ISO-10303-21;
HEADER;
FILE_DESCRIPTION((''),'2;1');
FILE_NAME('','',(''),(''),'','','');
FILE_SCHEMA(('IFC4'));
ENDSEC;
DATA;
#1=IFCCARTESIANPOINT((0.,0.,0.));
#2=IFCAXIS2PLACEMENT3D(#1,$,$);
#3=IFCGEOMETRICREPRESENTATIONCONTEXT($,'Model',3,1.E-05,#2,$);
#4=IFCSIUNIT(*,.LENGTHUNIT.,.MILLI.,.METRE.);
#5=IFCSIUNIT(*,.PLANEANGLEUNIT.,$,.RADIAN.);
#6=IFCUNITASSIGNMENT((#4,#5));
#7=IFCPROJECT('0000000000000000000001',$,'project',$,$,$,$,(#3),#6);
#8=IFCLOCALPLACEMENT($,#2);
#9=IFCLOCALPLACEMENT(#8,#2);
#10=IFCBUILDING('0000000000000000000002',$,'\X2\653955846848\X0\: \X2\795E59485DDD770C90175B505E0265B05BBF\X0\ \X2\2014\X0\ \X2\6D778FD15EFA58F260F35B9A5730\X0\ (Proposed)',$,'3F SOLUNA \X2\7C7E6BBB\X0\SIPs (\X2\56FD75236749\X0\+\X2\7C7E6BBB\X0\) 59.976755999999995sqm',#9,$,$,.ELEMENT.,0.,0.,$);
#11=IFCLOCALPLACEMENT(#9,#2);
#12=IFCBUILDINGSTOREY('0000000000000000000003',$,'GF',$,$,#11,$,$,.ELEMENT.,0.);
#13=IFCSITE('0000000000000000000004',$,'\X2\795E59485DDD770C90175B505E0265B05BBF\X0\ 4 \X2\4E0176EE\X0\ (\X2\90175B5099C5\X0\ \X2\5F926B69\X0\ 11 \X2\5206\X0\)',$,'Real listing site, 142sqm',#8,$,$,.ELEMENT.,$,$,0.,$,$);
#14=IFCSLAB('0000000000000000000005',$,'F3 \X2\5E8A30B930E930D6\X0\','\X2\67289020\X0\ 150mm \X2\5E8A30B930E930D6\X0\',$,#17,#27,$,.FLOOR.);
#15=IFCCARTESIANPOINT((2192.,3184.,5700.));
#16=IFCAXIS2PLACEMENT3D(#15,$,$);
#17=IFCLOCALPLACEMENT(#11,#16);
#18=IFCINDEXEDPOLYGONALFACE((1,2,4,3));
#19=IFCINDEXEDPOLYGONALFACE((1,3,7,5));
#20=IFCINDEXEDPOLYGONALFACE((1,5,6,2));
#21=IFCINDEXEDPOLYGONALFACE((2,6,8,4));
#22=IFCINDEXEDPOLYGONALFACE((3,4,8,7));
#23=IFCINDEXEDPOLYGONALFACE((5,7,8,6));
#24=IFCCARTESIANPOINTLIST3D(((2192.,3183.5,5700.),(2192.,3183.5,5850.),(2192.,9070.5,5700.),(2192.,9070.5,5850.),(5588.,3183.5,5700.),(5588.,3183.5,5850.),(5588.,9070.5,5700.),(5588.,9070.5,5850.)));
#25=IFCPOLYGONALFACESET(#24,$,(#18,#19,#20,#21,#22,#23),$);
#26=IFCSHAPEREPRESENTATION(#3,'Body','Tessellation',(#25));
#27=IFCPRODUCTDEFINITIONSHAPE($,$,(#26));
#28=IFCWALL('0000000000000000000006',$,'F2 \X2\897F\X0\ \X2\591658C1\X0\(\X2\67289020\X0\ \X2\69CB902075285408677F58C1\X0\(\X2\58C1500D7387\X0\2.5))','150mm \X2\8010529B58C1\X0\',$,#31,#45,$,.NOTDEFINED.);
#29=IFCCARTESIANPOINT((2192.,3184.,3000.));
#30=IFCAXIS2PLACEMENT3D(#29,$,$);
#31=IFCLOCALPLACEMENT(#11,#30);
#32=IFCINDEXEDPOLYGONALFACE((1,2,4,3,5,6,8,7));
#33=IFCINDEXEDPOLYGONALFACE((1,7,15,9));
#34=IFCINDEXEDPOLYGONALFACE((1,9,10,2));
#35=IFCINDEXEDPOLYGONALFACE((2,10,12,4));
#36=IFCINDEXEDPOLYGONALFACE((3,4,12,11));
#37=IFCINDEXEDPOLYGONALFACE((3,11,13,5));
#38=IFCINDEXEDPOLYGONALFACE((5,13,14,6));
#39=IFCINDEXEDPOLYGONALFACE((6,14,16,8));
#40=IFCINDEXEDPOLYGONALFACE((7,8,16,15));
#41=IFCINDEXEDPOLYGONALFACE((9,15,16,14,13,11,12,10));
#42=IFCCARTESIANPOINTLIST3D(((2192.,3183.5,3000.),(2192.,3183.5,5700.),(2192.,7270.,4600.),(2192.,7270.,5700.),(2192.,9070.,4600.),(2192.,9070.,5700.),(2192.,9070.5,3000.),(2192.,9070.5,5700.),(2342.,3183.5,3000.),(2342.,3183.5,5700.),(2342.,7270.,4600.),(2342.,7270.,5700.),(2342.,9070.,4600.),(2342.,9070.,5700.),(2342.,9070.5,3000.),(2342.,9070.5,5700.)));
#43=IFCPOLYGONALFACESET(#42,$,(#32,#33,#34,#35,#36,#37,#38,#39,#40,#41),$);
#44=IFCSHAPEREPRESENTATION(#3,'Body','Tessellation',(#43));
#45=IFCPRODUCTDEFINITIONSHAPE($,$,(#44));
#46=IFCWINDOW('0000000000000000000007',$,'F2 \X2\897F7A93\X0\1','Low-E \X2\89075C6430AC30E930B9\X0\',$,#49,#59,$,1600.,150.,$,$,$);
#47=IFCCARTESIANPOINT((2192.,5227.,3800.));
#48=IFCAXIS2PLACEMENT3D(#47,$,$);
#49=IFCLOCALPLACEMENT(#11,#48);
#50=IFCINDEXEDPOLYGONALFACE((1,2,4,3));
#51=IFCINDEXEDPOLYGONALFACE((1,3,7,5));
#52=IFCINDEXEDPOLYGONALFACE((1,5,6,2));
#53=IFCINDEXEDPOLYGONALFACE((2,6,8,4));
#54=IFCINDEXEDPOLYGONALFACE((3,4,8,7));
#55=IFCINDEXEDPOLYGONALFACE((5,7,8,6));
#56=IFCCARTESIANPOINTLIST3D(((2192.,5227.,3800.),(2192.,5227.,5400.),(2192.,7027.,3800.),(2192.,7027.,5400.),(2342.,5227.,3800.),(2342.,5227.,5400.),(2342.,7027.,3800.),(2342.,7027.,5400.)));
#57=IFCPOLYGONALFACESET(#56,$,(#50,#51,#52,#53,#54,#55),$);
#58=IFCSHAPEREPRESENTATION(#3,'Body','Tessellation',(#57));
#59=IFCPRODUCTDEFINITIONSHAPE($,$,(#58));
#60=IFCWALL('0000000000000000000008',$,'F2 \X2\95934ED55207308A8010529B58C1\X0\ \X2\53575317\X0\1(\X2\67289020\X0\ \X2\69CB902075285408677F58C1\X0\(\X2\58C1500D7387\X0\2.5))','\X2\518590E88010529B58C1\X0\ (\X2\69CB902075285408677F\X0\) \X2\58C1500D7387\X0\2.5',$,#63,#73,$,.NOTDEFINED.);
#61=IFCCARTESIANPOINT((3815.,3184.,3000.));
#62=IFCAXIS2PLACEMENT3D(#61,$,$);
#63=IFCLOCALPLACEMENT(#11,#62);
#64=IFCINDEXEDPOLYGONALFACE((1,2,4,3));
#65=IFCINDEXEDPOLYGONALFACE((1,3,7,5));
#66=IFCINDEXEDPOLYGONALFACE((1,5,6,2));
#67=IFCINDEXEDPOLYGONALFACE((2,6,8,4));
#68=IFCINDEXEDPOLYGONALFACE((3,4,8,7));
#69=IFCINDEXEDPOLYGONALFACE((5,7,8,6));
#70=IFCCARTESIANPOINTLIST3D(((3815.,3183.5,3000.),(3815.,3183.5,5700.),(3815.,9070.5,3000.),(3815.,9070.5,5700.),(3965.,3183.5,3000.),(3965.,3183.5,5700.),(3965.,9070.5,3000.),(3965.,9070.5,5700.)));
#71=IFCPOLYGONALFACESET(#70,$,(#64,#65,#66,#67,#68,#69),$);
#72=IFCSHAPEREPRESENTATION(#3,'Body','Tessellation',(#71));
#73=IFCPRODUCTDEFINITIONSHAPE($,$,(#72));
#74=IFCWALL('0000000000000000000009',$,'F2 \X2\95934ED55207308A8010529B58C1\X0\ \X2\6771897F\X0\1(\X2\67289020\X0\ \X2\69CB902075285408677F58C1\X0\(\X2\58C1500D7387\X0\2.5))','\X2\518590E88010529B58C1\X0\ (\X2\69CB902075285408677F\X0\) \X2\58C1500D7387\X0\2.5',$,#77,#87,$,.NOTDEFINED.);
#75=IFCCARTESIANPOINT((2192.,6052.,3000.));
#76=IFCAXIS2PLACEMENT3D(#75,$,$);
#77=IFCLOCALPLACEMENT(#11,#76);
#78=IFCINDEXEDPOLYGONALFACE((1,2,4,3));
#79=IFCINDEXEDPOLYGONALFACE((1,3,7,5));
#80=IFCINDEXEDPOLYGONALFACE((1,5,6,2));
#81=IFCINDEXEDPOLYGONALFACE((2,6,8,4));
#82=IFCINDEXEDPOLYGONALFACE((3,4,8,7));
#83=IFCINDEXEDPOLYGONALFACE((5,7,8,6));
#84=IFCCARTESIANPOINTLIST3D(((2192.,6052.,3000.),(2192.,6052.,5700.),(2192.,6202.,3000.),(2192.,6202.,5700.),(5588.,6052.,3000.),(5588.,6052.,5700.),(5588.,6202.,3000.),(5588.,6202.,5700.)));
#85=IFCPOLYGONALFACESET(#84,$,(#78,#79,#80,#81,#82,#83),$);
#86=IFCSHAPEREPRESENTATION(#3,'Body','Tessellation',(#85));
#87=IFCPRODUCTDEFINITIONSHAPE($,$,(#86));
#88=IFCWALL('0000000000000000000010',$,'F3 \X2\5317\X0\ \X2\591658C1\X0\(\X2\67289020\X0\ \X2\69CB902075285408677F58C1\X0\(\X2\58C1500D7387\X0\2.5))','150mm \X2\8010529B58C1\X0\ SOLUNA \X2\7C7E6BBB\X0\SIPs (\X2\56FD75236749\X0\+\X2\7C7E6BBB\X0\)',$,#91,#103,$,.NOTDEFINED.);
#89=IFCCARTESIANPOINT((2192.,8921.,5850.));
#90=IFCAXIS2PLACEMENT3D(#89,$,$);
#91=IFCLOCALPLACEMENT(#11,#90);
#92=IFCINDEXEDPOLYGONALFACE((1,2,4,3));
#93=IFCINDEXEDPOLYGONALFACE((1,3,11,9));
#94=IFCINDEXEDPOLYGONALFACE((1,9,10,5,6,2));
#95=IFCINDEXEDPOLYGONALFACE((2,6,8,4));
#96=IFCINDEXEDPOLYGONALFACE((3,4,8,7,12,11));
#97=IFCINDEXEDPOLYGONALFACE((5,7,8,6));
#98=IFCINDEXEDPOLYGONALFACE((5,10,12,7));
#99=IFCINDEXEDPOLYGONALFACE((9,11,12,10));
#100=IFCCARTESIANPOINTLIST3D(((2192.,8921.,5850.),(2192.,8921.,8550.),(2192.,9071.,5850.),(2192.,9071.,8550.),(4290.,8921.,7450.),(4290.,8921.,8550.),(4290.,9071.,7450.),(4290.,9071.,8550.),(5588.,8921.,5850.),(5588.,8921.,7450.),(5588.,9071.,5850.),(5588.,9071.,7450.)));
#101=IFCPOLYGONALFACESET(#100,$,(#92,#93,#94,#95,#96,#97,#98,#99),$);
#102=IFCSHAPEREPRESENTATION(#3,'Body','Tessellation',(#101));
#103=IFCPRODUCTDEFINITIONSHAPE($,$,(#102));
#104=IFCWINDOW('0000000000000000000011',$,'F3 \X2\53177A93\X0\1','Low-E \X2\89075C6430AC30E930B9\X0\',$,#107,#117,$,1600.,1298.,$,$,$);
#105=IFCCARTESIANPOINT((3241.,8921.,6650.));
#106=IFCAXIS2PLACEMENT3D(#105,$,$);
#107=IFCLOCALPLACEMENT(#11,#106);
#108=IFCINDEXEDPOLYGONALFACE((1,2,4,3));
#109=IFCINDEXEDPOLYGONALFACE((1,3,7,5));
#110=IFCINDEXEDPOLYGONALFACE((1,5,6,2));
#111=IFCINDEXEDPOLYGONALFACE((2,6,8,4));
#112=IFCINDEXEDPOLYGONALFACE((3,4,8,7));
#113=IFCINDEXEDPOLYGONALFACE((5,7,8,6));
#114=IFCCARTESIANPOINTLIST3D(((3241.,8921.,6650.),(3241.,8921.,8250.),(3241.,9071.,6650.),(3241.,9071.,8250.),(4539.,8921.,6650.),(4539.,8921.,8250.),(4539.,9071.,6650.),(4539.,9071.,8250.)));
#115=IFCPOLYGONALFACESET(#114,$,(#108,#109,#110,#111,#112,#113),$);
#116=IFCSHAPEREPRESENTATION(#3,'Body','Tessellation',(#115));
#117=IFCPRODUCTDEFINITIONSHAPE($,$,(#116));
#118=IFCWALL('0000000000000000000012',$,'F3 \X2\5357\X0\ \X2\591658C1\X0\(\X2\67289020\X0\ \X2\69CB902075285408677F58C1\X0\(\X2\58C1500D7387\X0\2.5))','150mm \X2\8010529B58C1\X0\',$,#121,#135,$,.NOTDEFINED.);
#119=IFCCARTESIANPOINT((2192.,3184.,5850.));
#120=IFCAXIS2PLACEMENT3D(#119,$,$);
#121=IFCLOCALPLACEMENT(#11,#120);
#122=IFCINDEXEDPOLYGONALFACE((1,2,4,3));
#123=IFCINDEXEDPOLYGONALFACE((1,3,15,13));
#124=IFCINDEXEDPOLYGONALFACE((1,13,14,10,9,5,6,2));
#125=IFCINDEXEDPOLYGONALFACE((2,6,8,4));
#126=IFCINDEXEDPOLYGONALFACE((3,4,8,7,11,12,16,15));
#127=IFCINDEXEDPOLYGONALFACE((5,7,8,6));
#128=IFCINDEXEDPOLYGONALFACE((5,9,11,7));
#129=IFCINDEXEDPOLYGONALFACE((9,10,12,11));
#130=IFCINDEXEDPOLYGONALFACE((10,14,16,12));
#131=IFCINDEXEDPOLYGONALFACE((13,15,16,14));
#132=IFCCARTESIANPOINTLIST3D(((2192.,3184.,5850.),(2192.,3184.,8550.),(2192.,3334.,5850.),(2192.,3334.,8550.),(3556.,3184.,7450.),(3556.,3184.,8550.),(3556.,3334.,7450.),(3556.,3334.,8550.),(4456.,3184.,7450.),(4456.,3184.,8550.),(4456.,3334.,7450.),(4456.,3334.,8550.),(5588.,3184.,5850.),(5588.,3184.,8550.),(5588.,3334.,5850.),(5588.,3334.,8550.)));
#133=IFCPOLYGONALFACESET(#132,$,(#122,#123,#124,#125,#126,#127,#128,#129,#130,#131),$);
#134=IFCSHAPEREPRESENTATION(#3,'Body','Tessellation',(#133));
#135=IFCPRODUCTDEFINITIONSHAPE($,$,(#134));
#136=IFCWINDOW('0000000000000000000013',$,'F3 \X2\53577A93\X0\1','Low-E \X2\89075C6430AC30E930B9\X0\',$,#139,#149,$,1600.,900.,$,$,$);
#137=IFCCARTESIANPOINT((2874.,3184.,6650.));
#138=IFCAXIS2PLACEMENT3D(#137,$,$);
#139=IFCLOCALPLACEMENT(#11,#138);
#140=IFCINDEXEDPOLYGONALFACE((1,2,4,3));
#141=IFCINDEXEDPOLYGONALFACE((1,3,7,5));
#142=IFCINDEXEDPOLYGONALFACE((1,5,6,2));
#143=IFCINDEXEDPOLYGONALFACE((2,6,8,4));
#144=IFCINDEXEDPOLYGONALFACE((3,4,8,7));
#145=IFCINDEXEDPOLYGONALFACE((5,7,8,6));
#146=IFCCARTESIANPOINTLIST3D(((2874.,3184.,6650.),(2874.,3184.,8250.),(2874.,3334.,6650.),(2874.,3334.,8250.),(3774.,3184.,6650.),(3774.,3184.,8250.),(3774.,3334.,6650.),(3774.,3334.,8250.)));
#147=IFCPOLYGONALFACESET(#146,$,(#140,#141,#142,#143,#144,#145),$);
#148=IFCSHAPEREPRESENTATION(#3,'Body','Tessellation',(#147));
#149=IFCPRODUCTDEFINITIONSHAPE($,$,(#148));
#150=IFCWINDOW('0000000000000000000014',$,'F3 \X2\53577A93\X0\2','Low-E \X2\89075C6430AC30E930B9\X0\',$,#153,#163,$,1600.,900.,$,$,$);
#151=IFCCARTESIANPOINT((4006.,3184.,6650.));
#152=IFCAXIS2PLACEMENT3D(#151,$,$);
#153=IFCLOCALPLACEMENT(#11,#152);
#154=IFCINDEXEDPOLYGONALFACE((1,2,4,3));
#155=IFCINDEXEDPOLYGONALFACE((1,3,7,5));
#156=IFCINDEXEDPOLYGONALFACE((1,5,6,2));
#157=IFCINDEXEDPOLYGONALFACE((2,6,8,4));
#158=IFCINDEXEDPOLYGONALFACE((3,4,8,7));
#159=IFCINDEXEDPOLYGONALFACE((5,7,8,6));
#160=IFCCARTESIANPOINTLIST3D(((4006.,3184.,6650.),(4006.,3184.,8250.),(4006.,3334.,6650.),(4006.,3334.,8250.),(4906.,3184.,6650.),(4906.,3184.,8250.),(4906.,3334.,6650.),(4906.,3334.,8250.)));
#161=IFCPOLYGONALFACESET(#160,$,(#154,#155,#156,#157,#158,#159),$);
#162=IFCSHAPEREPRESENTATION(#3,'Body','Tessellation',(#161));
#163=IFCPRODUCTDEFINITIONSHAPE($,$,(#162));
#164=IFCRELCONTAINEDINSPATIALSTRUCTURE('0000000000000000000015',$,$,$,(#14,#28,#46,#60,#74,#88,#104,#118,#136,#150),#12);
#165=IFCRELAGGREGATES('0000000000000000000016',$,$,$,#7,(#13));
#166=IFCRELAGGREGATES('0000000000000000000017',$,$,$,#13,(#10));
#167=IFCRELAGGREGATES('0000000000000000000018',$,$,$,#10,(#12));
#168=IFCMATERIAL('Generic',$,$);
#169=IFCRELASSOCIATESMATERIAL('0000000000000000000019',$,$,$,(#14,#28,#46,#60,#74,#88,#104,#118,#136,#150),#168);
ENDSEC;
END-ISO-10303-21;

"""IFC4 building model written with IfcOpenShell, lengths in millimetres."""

from ifc_helpers import new_model, si_unit, frame, frame_2d, origin, place, context, project, spatial, rectangle, extrude, material, element, fill, save


model = new_model("IFC4")

# Units and contexts
model_context = context("Model", 3, precision=1e-05, world=origin())
ifc_project = project(units=[si_unit("LENGTHUNIT", "METRE", prefix="MILLI"), si_unit("PLANEANGLEUNIT", "RADIAN")], contexts=[model_context])

# Site, building, storey
site_placement = place(None, origin())
site = spatial("IfcSite", under=ifc_project, at=site_placement, Name="神奈川県逗子市新宿 4 丁目 (逗子駅 徒歩 11 分)", ObjectType="Real listing site, 142sqm", CompositionType="ELEMENT", RefElevation=0.0)
building_placement = place(site_placement, origin())
building = spatial("IfcBuilding", under=site, at=building_placement, Name="改善案: 神奈川県逗子市新宿 — 海近建売想定地 (Proposed)", ObjectType="3F SOLUNA 籾殻SIPs (国産杉+籾殻) 59.976755999999995sqm", CompositionType="ELEMENT", ElevationOfRefHeight=0.0, ElevationOfTerrain=0.0)
storey_placement = place(building_placement, origin())
storey = spatial("IfcBuildingStorey", under=building, at=storey_placement, Name="GF", CompositionType="ELEMENT", Elevation=0.0)

# Slab
ifc_material_1 = material(Name="Generic")
slab_placement = place(storey_placement, frame((2192.0, 3184.0, 5700.0)))
element("IfcSlab", 1, at=slab_placement, inside=storey, material=ifc_material_1, Name="F3 床スラブ", Description="木造 150mm 床スラブ", PredefinedType="FLOOR", context=model_context, shape_type="SweptSolid", body=[
    extrude(rectangle(XDim=3396.0, YDim=5887.0, at=frame_2d((1698.0, 2943.0))), frame((2192.0, 3184.0, 5700.0)), (0.0, 0.0, 1.0), 150.0),
])

# Wall, opening, window
wall_1_placement = place(storey_placement, frame((2192.0, 3184.0, 3000.0)))
wall_1 = element("IfcWall", 2, at=wall_1_placement, inside=storey, material=ifc_material_1, Name="F2 西 外壁(木造 構造用合板壁(壁倍率2.5))", Description="150mm 耐力壁", PredefinedType="NOTDEFINED", context=model_context, shape_type="SweptSolid", body=[
    extrude(rectangle(XDim=150.0, YDim=5887.0, at=frame_2d((75.0, 2943.0))), frame((2192.0, 3184.0, 3000.0)), (0.0, 0.0, 1.0), 2700.0),
])
opening_1_placement = place(storey_placement, frame((2192.0, 5227.0, 3800.0)))
opening_1 = element("IfcOpeningElement", 3, at=opening_1_placement, cuts=wall_1, PredefinedType="NOTDEFINED", context=model_context, shape_type="SweptSolid", body=[
    extrude(rectangle(XDim=150.0, YDim=1800.0, at=frame_2d((75.0, 900.0))), frame((2192.0, 5227.0, 3800.0)), (0.0, 0.0, 1.0), 1600.0),
])
window_1_placement = place(storey_placement, frame((2192.0, 5227.0, 3800.0)))
window_1 = element("IfcWindow", 4, at=window_1_placement, inside=storey, material=ifc_material_1, Name="F2 西窓1", Description="Low-E 複層ガラス", OverallHeight=1600.0, OverallWidth=150.0, context=model_context, shape_type="SweptSolid", body=[
    extrude(rectangle(XDim=150.0, YDim=1800.0, at=frame_2d((75.0, 900.0))), frame((2192.0, 5227.0, 3800.0)), (0.0, 0.0, 1.0), 1600.0),
])
fill(opening_1, window_1)

# Walls
wall_2_placement = place(storey_placement, frame((3815.0, 3184.0, 3000.0)))
element("IfcWall", 5, at=wall_2_placement, inside=storey, material=ifc_material_1, Name="F2 間仕切り耐力壁 南北1(木造 構造用合板壁(壁倍率2.5))", Description="内部耐力壁 (構造用合板) 壁倍率2.5", PredefinedType="NOTDEFINED", context=model_context, shape_type="SweptSolid", body=[
    extrude(rectangle(XDim=150.0, YDim=5887.0, at=frame_2d((75.0, 2943.0))), frame((3815.0, 3184.0, 3000.0)), (0.0, 0.0, 1.0), 2700.0),
])
wall_3_placement = place(storey_placement, frame((2192.0, 6052.0, 3000.0)))
element("IfcWall", 6, at=wall_3_placement, inside=storey, material=ifc_material_1, Name="F2 間仕切り耐力壁 東西1(木造 構造用合板壁(壁倍率2.5))", Description="内部耐力壁 (構造用合板) 壁倍率2.5", PredefinedType="NOTDEFINED", context=model_context, shape_type="SweptSolid", body=[
    extrude(rectangle(XDim=3396.0, YDim=150.0, at=frame_2d((1698.0, 75.0))), frame((2192.0, 6052.0, 3000.0)), (0.0, 0.0, 1.0), 2700.0),
])

# Wall, opening, window
wall_4_placement = place(storey_placement, frame((2192.0, 8921.0, 5850.0)))
wall_4 = element("IfcWall", 7, at=wall_4_placement, inside=storey, material=ifc_material_1, Name="F3 北 外壁(木造 構造用合板壁(壁倍率2.5))", Description="150mm 耐力壁 SOLUNA 籾殻SIPs (国産杉+籾殻)", PredefinedType="NOTDEFINED", context=model_context, shape_type="SweptSolid", body=[
    extrude(rectangle(XDim=3396.0, YDim=150.0, at=frame_2d((1698.0, 75.0))), frame((2192.0, 8921.0, 5850.0)), (0.0, 0.0, 1.0), 2700.0),
])
opening_2_placement = place(storey_placement, frame((3241.0, 8921.0, 6650.0)))
opening_2 = element("IfcOpeningElement", 8, at=opening_2_placement, cuts=wall_4, PredefinedType="NOTDEFINED", context=model_context, shape_type="SweptSolid", body=[
    extrude(rectangle(XDim=1298.0, YDim=150.0, at=frame_2d((649.0, 75.0))), frame((3241.0, 8921.0, 6650.0)), (0.0, 0.0, 1.0), 1600.0),
])
window_2_placement = place(storey_placement, frame((3241.0, 8921.0, 6650.0)))
window_2 = element("IfcWindow", 9, at=window_2_placement, inside=storey, material=ifc_material_1, Name="F3 北窓1", Description="Low-E 複層ガラス", OverallHeight=1600.0, OverallWidth=1298.0, context=model_context, shape_type="SweptSolid", body=[
    extrude(rectangle(XDim=1298.0, YDim=150.0, at=frame_2d((649.0, 75.0))), frame((3241.0, 8921.0, 6650.0)), (0.0, 0.0, 1.0), 1600.0),
])
fill(opening_2, window_2)

# Wall, openings, windows
wall_5_placement = place(storey_placement, frame((2192.0, 3184.0, 5850.0)))
wall_5 = element("IfcWall", 10, at=wall_5_placement, inside=storey, material=ifc_material_1, Name="F3 南 外壁(木造 構造用合板壁(壁倍率2.5))", Description="150mm 耐力壁", PredefinedType="NOTDEFINED", context=model_context, shape_type="SweptSolid", body=[
    extrude(rectangle(XDim=3396.0, YDim=150.0, at=frame_2d((1698.0, 75.0))), frame((2192.0, 3184.0, 5850.0)), (0.0, 0.0, 1.0), 2700.0),
])
opening_3_placement = place(storey_placement, frame((2874.0, 3184.0, 6650.0)))
opening_3 = element("IfcOpeningElement", 11, at=opening_3_placement, cuts=wall_5, PredefinedType="NOTDEFINED", context=model_context, shape_type="SweptSolid", body=[
    extrude(rectangle(XDim=900.0, YDim=150.0, at=frame_2d((450.0, 75.0))), frame((2874.0, 3184.0, 6650.0)), (0.0, 0.0, 1.0), 1600.0),
])
opening_4_placement = place(storey_placement, frame((4006.0, 3184.0, 6650.0)))
opening_4 = element("IfcOpeningElement", 12, at=opening_4_placement, cuts=wall_5, PredefinedType="NOTDEFINED", context=model_context, shape_type="SweptSolid", body=[
    extrude(rectangle(XDim=900.0, YDim=150.0, at=frame_2d((450.0, 75.0))), frame((4006.0, 3184.0, 6650.0)), (0.0, 0.0, 1.0), 1600.0),
])
window_3_placement = place(storey_placement, frame((2874.0, 3184.0, 6650.0)))
window_3 = element("IfcWindow", 13, at=window_3_placement, inside=storey, material=ifc_material_1, Name="F3 南窓1", Description="Low-E 複層ガラス", OverallHeight=1600.0, OverallWidth=900.0, context=model_context, shape_type="SweptSolid", body=[
    extrude(rectangle(XDim=900.0, YDim=150.0, at=frame_2d((450.0, 75.0))), frame((2874.0, 3184.0, 6650.0)), (0.0, 0.0, 1.0), 1600.0),
])
fill(opening_3, window_3)
window_4_placement = place(storey_placement, frame((4006.0, 3184.0, 6650.0)))
window_4 = element("IfcWindow", 14, at=window_4_placement, inside=storey, material=ifc_material_1, Name="F3 南窓2", Description="Low-E 複層ガラス", OverallHeight=1600.0, OverallWidth=900.0, context=model_context, shape_type="SweptSolid", body=[
    extrude(rectangle(XDim=900.0, YDim=150.0, at=frame_2d((450.0, 75.0))), frame((4006.0, 3184.0, 6650.0)), (0.0, 0.0, 1.0), 1600.0),
])
fill(opening_4, window_4)

save(model, "model.ifc")
